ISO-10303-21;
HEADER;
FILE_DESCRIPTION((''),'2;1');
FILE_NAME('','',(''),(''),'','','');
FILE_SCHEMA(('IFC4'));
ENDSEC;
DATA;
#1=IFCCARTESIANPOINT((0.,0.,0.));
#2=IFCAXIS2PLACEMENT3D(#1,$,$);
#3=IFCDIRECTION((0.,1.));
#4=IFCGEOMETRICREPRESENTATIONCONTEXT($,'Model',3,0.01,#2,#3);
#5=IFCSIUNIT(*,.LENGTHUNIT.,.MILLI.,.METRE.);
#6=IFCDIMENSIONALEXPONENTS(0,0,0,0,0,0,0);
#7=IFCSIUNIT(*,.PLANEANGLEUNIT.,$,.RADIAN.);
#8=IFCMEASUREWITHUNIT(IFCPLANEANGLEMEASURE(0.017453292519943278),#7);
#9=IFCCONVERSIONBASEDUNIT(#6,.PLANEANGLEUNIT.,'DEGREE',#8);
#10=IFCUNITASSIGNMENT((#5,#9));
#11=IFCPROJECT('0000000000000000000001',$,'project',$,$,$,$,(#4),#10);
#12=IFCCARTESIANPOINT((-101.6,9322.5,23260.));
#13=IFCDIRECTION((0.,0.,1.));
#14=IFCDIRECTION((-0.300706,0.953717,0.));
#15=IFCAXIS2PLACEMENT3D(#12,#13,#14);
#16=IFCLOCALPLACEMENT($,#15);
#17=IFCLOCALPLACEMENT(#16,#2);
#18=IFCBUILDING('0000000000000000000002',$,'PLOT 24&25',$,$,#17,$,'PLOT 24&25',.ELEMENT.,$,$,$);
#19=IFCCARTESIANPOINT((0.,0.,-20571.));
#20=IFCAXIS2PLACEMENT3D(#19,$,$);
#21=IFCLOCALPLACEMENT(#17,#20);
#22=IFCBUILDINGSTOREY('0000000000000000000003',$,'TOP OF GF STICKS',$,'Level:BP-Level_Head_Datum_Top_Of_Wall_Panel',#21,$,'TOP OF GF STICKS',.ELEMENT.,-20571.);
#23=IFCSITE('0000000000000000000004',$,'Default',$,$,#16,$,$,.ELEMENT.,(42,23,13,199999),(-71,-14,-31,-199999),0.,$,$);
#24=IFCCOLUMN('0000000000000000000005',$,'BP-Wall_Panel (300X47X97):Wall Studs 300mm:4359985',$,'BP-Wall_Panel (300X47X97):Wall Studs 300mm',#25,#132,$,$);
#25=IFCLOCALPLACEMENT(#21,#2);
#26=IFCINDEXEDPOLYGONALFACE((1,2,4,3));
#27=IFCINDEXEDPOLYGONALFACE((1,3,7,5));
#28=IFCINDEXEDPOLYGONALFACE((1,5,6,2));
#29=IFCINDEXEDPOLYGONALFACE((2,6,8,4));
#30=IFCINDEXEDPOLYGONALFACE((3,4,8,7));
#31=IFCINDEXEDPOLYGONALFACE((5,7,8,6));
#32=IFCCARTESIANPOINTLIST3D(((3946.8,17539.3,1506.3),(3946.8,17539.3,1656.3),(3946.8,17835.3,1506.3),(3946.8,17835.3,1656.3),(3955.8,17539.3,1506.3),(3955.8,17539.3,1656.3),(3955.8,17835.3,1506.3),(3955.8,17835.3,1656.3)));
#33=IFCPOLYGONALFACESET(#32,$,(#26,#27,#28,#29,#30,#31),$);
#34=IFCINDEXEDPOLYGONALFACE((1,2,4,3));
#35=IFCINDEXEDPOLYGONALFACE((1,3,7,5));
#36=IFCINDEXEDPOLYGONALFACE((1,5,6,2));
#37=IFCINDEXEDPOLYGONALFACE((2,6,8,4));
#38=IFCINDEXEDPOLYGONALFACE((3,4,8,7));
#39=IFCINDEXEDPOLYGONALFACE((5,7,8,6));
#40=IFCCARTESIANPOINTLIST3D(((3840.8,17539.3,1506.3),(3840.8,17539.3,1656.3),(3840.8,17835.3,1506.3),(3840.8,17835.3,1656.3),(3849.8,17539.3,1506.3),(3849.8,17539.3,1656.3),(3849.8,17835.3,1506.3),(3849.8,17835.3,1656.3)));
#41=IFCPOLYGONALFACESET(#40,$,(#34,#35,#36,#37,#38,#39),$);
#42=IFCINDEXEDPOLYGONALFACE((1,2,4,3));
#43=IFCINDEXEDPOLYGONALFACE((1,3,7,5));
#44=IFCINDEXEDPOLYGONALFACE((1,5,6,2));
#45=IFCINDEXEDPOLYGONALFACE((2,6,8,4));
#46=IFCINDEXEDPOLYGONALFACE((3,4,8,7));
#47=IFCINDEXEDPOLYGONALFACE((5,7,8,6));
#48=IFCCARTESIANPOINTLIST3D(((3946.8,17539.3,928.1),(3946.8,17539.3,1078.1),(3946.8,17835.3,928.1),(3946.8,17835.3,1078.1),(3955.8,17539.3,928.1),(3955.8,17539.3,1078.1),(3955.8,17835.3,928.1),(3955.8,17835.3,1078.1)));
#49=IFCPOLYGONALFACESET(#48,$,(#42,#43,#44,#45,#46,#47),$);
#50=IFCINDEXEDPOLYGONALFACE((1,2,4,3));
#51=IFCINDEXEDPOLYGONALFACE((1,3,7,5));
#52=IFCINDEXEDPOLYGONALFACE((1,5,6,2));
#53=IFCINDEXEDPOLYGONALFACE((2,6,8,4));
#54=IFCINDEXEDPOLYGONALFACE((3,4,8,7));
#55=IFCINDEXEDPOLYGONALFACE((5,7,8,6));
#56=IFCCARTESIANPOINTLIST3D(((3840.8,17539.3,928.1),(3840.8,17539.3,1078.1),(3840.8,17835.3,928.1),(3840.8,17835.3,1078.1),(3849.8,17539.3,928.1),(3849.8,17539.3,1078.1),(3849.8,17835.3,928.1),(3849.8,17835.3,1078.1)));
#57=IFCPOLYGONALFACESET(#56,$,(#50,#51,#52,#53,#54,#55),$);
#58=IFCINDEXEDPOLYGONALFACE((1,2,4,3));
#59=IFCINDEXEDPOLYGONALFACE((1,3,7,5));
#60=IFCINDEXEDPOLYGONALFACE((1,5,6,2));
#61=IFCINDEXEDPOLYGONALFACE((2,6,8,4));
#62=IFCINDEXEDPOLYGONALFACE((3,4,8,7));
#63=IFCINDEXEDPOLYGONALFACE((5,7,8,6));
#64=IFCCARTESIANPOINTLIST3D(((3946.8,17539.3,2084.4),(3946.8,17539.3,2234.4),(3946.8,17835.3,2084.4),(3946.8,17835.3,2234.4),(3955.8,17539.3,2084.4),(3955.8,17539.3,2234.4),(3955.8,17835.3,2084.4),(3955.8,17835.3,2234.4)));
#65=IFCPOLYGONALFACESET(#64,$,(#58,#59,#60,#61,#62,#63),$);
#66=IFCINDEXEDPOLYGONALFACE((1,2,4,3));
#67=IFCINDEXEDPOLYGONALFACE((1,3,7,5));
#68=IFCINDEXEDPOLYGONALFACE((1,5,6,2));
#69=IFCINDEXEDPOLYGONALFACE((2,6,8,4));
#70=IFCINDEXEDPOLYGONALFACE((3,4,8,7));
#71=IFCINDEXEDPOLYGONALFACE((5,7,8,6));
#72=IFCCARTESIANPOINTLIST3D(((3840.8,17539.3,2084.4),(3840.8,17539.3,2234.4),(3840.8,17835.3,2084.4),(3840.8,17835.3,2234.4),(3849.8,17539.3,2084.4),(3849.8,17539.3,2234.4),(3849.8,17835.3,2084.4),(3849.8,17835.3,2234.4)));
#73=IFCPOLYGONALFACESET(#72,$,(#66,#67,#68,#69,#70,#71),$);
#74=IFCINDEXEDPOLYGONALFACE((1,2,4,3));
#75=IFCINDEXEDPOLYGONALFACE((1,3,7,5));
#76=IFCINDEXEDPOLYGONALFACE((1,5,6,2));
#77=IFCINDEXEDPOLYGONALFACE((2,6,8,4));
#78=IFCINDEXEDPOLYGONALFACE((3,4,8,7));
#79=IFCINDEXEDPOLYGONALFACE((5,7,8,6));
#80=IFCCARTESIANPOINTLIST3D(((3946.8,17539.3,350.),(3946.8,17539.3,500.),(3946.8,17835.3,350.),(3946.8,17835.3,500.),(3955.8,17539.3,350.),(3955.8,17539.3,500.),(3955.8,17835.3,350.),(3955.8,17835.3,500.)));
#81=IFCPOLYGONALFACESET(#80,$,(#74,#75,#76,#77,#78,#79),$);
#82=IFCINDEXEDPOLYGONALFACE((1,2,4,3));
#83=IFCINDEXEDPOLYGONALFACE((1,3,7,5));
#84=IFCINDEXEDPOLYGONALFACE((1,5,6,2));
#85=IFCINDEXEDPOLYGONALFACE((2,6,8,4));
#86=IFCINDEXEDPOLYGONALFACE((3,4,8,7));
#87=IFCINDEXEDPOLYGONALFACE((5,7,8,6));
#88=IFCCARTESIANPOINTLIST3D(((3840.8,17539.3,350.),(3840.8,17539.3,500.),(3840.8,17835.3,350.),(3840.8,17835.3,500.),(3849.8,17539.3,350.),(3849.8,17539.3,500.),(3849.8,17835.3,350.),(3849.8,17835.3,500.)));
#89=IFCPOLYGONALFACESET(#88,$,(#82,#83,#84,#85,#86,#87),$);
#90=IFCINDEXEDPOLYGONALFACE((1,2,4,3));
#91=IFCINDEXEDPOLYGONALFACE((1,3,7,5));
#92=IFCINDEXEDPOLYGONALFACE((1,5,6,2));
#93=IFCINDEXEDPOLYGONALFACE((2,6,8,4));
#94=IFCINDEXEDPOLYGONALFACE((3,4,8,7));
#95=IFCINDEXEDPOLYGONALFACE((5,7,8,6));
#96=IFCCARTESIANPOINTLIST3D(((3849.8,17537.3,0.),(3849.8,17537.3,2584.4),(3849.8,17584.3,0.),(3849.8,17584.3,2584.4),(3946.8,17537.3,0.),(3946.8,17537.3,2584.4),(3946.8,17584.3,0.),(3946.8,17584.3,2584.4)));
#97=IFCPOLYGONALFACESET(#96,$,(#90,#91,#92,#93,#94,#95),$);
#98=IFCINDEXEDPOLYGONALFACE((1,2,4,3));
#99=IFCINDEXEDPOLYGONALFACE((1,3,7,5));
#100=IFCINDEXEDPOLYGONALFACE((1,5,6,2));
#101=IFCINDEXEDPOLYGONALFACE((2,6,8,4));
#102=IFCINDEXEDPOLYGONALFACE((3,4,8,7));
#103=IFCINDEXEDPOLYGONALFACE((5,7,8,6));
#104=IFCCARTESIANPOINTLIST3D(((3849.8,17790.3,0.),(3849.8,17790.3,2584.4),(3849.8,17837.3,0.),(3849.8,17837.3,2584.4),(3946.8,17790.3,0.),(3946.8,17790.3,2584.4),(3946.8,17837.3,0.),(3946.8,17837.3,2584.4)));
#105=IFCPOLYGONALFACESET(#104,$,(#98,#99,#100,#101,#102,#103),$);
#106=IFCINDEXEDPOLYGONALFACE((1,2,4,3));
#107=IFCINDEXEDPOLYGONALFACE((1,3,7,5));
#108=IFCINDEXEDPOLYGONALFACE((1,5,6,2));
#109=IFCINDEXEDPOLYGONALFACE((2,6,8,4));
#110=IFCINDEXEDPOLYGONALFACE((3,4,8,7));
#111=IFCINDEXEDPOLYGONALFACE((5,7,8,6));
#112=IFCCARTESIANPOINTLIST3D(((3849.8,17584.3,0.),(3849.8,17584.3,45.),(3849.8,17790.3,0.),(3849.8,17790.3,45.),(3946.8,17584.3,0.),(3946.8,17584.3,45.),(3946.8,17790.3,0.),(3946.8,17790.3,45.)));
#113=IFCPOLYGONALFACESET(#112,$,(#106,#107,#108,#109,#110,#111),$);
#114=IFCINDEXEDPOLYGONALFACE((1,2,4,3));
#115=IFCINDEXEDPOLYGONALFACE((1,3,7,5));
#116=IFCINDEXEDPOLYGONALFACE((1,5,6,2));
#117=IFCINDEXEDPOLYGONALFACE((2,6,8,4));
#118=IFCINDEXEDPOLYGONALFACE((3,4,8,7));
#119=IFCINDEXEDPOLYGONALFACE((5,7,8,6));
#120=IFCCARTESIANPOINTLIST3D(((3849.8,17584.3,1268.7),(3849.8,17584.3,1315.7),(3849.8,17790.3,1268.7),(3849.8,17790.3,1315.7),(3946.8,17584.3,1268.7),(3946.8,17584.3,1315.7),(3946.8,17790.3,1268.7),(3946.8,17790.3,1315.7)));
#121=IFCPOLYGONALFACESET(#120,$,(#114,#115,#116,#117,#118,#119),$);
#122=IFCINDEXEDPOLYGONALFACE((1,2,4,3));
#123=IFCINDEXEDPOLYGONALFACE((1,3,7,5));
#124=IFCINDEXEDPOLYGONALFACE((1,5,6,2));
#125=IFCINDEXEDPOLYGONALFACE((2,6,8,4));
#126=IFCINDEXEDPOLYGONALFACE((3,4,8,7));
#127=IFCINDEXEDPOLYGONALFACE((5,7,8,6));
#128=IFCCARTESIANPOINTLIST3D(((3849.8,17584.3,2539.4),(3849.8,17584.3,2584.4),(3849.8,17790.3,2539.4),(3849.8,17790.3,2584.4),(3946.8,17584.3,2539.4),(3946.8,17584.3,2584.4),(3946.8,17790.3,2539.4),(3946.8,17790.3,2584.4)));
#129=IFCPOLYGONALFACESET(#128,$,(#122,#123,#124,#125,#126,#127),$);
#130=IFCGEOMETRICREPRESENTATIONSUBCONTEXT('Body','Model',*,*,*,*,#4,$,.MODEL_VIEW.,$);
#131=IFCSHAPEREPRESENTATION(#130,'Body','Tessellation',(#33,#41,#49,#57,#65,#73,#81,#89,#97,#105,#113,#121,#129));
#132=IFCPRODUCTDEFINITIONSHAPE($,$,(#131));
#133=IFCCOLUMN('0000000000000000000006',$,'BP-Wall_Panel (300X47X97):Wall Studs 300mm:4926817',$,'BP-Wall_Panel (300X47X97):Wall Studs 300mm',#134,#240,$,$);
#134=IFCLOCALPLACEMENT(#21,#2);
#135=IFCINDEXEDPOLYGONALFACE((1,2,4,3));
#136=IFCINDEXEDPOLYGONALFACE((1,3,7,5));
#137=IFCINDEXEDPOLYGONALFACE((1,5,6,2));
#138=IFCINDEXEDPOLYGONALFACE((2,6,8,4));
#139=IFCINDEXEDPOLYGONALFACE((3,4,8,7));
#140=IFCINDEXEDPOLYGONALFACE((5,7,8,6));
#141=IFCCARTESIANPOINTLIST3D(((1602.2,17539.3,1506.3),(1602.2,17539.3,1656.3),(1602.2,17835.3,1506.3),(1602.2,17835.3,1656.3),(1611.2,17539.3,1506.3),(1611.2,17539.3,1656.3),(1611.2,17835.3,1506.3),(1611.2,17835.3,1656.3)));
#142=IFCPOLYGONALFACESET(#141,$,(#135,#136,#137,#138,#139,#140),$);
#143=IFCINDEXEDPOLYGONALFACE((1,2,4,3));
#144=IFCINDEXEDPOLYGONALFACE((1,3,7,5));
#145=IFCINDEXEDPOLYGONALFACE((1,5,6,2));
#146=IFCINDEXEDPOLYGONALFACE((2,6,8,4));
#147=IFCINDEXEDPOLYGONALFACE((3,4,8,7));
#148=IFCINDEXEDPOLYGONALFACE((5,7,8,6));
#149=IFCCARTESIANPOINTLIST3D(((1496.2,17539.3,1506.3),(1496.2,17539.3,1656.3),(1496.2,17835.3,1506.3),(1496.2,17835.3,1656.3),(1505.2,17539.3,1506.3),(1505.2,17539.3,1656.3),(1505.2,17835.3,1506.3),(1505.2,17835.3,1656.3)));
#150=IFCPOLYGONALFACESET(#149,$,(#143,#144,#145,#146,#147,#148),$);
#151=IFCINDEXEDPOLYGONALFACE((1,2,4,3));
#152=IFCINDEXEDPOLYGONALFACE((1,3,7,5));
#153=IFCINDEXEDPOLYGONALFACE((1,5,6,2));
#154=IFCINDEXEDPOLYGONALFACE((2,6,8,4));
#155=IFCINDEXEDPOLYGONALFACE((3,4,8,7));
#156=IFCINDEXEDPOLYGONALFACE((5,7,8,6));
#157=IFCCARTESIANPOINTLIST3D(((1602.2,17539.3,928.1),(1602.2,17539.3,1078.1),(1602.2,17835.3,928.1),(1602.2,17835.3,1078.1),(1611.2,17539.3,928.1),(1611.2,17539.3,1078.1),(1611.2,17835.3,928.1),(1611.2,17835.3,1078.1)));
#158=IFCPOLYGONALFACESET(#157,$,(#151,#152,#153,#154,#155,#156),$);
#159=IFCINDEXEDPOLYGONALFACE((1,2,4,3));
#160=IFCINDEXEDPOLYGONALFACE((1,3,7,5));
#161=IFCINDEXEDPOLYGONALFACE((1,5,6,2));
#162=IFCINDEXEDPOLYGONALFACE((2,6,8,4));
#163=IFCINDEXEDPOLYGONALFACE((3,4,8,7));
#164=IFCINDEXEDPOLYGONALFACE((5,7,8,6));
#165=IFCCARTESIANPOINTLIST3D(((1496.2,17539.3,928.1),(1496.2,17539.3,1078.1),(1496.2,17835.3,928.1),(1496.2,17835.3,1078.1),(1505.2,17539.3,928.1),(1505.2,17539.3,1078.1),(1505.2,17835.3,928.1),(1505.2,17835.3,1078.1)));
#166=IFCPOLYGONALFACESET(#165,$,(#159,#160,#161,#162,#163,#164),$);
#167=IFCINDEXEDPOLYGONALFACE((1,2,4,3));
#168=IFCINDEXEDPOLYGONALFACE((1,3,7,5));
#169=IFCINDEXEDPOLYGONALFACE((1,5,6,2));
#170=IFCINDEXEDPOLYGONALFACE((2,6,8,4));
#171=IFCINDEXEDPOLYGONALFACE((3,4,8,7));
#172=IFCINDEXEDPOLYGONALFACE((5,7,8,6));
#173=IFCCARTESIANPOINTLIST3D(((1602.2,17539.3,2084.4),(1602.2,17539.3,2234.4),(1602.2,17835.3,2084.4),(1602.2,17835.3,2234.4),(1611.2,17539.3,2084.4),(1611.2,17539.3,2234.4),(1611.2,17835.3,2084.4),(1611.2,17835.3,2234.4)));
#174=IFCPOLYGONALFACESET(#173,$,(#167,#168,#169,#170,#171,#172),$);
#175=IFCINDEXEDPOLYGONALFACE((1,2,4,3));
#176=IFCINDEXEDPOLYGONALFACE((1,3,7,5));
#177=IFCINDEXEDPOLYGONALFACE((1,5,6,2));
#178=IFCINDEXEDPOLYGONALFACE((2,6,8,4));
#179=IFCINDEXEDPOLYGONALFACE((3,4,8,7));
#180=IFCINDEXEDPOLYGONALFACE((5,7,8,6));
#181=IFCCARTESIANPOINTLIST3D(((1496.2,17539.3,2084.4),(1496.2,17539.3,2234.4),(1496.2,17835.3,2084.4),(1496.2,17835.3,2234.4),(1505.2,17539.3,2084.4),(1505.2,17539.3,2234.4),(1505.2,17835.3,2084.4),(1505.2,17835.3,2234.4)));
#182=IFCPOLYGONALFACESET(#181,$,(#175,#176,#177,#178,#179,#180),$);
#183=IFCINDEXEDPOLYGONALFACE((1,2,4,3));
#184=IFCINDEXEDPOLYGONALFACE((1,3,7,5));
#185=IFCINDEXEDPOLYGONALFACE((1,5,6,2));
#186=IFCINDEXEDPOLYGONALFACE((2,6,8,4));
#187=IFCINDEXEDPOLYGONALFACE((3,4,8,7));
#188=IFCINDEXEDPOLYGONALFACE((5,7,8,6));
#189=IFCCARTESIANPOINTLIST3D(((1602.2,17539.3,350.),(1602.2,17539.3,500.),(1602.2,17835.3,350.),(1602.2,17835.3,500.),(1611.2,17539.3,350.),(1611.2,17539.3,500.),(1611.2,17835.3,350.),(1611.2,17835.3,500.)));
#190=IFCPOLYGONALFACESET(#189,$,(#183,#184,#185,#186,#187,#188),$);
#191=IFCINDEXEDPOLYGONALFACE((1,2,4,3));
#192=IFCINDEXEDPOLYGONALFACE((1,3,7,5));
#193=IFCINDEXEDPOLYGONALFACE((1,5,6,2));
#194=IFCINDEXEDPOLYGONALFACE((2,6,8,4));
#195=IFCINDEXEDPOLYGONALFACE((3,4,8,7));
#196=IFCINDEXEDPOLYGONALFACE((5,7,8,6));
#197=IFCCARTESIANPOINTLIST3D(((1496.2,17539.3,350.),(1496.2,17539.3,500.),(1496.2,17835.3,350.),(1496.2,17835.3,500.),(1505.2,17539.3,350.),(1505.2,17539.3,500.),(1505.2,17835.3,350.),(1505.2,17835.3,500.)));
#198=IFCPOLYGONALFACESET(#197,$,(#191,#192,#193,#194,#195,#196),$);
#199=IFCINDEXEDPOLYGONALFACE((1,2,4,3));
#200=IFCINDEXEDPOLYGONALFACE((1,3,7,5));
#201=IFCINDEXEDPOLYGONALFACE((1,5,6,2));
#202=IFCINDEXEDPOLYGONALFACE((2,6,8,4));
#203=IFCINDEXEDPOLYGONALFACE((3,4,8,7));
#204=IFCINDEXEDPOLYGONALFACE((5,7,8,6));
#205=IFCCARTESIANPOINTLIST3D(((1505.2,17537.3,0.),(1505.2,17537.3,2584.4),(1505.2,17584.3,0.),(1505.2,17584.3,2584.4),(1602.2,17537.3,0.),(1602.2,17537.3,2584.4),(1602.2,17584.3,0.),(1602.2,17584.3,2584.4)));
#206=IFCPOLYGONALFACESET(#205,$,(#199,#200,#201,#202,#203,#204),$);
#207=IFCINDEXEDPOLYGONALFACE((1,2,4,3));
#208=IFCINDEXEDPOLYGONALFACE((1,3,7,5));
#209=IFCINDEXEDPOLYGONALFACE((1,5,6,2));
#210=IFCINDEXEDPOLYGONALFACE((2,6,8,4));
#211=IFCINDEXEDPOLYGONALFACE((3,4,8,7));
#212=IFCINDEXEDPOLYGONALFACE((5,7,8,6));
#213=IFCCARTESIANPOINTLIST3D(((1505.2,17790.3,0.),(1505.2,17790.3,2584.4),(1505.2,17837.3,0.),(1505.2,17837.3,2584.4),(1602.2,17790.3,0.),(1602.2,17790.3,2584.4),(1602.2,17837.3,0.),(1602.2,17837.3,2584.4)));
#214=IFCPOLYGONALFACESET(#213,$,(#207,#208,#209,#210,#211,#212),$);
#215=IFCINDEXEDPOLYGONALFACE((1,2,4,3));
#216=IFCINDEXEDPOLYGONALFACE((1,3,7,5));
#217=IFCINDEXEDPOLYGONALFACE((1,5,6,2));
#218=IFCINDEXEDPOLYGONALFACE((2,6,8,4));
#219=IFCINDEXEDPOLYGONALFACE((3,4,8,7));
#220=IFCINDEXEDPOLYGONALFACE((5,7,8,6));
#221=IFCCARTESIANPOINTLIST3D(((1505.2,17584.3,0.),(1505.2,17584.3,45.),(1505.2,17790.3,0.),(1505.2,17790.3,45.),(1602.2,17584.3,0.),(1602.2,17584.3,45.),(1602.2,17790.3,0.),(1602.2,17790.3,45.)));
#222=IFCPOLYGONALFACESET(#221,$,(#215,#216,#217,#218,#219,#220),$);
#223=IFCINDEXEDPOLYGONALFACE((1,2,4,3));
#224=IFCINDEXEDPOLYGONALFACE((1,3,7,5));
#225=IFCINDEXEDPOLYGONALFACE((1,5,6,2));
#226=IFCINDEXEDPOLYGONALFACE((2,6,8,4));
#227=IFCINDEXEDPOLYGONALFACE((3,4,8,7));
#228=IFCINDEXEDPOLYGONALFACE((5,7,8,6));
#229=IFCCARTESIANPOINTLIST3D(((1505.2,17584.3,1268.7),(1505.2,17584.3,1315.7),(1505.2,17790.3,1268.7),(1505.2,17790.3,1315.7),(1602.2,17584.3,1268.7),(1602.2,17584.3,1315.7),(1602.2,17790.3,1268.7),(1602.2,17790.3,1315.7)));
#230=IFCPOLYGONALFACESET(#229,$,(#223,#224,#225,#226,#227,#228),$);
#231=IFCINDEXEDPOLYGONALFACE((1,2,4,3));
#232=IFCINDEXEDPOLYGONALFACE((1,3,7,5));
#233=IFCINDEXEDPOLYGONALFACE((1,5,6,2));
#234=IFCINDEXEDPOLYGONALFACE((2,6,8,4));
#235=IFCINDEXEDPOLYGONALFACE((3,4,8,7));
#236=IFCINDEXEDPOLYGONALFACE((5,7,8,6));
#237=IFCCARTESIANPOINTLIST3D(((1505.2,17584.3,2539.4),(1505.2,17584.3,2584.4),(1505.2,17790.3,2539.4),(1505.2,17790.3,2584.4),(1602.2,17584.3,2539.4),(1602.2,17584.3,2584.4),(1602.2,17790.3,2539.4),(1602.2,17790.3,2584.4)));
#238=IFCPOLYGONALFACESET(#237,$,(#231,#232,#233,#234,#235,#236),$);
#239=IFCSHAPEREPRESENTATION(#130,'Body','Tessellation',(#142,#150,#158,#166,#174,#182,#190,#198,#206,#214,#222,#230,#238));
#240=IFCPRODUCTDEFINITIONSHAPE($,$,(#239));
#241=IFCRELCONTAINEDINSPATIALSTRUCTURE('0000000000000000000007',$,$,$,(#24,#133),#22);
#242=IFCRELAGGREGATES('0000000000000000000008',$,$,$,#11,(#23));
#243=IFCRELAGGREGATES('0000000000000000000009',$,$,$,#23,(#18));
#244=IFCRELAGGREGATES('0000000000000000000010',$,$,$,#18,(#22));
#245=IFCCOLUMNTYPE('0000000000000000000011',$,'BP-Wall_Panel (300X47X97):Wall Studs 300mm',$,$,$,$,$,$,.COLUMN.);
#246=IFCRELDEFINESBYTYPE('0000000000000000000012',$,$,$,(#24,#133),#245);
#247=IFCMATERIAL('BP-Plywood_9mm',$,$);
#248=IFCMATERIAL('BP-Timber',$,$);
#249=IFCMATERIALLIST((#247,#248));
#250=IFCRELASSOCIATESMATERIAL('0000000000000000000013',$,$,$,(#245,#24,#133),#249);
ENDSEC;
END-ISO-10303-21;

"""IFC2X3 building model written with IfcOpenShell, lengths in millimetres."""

from ifc_helpers import new_model, entity, si_unit, converted_unit, direction, frame, frame_2d, origin, origin_2d_with_axis, place, context, subcontext, project, spatial, rectangle, extrude, source, transform, mapped, material, material_list, type_object, type_shapes, element, save


model = new_model("IFC2X3")

# Units and contexts
model_context = context("Model", 3, precision=0.01, world=origin(), true_north=direction((0.0, 1.0)))
body_context = subcontext(model_context, "Body", "Model", "MODEL_VIEW")
ifc_project = project(units=[si_unit("LENGTHUNIT", "METRE", prefix="MILLI"), converted_unit("PLANEANGLEUNIT", "DEGREE", entity("IfcPlaneAngleMeasure", 0.017453292519943278), si_unit("PLANEANGLEUNIT", "RADIAN"), dimensions=[0, 0, 0, 0, 0, 0, 0])], contexts=[model_context])

# Site, building, storey
site_placement = place(None, frame((-101.6, 9322.5, 23260.0), z_axis=(0.0, 0.0, 1.0), x_axis=(-0.300706, 0.953717, 0.0)))
site = spatial("IfcSite", under=ifc_project, at=site_placement, Name="Default", CompositionType="ELEMENT", RefLatitude=(42, 23, 13, 199999), RefLongitude=(-71, -14, -31, -199999), RefElevation=0.0)
building_placement = place(site_placement, origin())
building = spatial("IfcBuilding", under=site, at=building_placement, Name="PLOT 24&25", LongName="PLOT 24&25", CompositionType="ELEMENT")
storey_placement = place(building_placement, frame((0.0, 0.0, -20571.0)))
storey = spatial("IfcBuildingStorey", under=building, at=storey_placement, Name="TOP OF GF STICKS", ObjectType="Level:BP-Level_Head_Datum_Top_Of_Wall_Panel", LongName="TOP OF GF STICKS", CompositionType="ELEMENT", Elevation=-20571.0)

# Columns
ifc_material_1 = material(Name="BP-Plywood_9mm")
ifc_material_2 = material(Name="BP-Timber")
ifc_material_list = material_list([ifc_material_1, ifc_material_2])
column_type_1 = type_object("IfcColumnType", Name="BP-Wall_Panel (300X47X97):Wall Studs 300mm", PredefinedType="COLUMN", material=ifc_material_list)
shared_shape_1 = source(origin(), body_context, "Body", "SweptSolid", [
    extrude(rectangle(XDim=296.0, YDim=9.0, at=origin_2d_with_axis()), frame((53.0, 0.0, -19064.7), z_axis=(0.0, 0.0, 1.0), x_axis=(0.0, -1.0, 0.0)), (0.0, 0.0, 1.0), 150.0),
    extrude(rectangle(XDim=9.0, YDim=296.0, at=origin_2d_with_axis()), frame((-53.0, 0.0, -19064.7), z_axis=(0.0, 0.0, 1.0), x_axis=(-1.0, 0.0, 0.0)), (0.0, 0.0, 1.0), 150.0),
    extrude(rectangle(XDim=296.0, YDim=9.0, at=origin_2d_with_axis()), frame((53.0, 0.0, -19642.9), z_axis=(0.0, 0.0, 1.0), x_axis=(0.0, -1.0, 0.0)), (0.0, 0.0, 1.0), 150.0),
    extrude(rectangle(XDim=9.0, YDim=296.0, at=origin_2d_with_axis()), frame((-53.0, 0.0, -19642.9), z_axis=(0.0, 0.0, 1.0), x_axis=(-1.0, 0.0, 0.0)), (0.0, 0.0, 1.0), 150.0),
    extrude(rectangle(XDim=296.0, YDim=9.0, at=origin_2d_with_axis()), frame((53.0, 0.0, -18486.6), z_axis=(0.0, 0.0, 1.0), x_axis=(0.0, -1.0, 0.0)), (0.0, 0.0, 1.0), 150.0),
    extrude(rectangle(XDim=9.0, YDim=296.0, at=origin_2d_with_axis()), frame((-53.0, 0.0, -18486.6), z_axis=(0.0, 0.0, 1.0), x_axis=(-1.0, 0.0, 0.0)), (0.0, 0.0, 1.0), 150.0),
    extrude(rectangle(XDim=296.0, YDim=9.0, at=origin_2d_with_axis()), frame((53.0, 0.0, -20221.0), z_axis=(0.0, 0.0, 1.0), x_axis=(0.0, -1.0, 0.0)), (0.0, 0.0, 1.0), 150.0),
    extrude(rectangle(XDim=9.0, YDim=296.0, at=origin_2d_with_axis()), frame((-53.0, 0.0, -20221.0), z_axis=(0.0, 0.0, 1.0), x_axis=(-1.0, 0.0, 0.0)), (0.0, 0.0, 1.0), 150.0),
    extrude(rectangle(XDim=97.0, YDim=47.0, at=origin_2d_with_axis()), frame((0.0, -126.5, -20571.0), z_axis=(0.0, 0.0, 1.0), x_axis=(-1.0, 0.0, 0.0)), (0.0, 0.0, 1.0), 2584.4),
    extrude(rectangle(XDim=97.0, YDim=47.0, at=frame_2d((0.0, 0.0), x_axis=(1.0, 0.0))), frame((0.0, 126.5, -20571.0), z_axis=(0.0, 0.0, 1.0), x_axis=(-1.0, 0.0, 0.0)), (0.0, 0.0, 1.0), 2584.4),
    extrude(rectangle(XDim=206.0, YDim=97.0, at=origin_2d_with_axis()), frame((0.0, 0.0, -20571.0), z_axis=(0.0, 0.0, 1.0), x_axis=(0.0, -1.0, 0.0)), (0.0, 0.0, 1.0), 45.0),
    extrude(rectangle(XDim=206.0, YDim=97.0, at=origin_2d_with_axis()), frame((0.0, 0.0, -19302.3), z_axis=(0.0, 0.0, 1.0), x_axis=(0.0, -1.0, 0.0)), (0.0, 0.0, 1.0), 47.0),
    extrude(rectangle(XDim=206.0, YDim=97.0, at=origin_2d_with_axis()), frame((0.0, 0.0, -18031.6), z_axis=(0.0, 0.0, 1.0), x_axis=(0.0, -1.0, 0.0)), (0.0, 0.0, 1.0), 45.0),
])
type_shapes(column_type_1, [shared_shape_1])
for number, where, name in (
    (1, (3898.3, 17687.3, 20571.0), "BP-Wall_Panel (300X47X97):Wall Studs 300mm:4359985"),
    (2, (1553.7, 17687.3, 20571.0), "BP-Wall_Panel (300X47X97):Wall Studs 300mm:4926817"),
):
    element("IfcColumn", number, at=place(storey_placement, frame(where)), inside=storey, type_object=column_type_1, material=ifc_material_list, Name=name, ObjectType="BP-Wall_Panel (300X47X97):Wall Studs 300mm", context=body_context, shape_type="MappedRepresentation", body=[
        mapped(shared_shape_1, transform((0.0, 0.0, 0.0), scale=1.0)),
    ])

save(model, "model.ifc")
